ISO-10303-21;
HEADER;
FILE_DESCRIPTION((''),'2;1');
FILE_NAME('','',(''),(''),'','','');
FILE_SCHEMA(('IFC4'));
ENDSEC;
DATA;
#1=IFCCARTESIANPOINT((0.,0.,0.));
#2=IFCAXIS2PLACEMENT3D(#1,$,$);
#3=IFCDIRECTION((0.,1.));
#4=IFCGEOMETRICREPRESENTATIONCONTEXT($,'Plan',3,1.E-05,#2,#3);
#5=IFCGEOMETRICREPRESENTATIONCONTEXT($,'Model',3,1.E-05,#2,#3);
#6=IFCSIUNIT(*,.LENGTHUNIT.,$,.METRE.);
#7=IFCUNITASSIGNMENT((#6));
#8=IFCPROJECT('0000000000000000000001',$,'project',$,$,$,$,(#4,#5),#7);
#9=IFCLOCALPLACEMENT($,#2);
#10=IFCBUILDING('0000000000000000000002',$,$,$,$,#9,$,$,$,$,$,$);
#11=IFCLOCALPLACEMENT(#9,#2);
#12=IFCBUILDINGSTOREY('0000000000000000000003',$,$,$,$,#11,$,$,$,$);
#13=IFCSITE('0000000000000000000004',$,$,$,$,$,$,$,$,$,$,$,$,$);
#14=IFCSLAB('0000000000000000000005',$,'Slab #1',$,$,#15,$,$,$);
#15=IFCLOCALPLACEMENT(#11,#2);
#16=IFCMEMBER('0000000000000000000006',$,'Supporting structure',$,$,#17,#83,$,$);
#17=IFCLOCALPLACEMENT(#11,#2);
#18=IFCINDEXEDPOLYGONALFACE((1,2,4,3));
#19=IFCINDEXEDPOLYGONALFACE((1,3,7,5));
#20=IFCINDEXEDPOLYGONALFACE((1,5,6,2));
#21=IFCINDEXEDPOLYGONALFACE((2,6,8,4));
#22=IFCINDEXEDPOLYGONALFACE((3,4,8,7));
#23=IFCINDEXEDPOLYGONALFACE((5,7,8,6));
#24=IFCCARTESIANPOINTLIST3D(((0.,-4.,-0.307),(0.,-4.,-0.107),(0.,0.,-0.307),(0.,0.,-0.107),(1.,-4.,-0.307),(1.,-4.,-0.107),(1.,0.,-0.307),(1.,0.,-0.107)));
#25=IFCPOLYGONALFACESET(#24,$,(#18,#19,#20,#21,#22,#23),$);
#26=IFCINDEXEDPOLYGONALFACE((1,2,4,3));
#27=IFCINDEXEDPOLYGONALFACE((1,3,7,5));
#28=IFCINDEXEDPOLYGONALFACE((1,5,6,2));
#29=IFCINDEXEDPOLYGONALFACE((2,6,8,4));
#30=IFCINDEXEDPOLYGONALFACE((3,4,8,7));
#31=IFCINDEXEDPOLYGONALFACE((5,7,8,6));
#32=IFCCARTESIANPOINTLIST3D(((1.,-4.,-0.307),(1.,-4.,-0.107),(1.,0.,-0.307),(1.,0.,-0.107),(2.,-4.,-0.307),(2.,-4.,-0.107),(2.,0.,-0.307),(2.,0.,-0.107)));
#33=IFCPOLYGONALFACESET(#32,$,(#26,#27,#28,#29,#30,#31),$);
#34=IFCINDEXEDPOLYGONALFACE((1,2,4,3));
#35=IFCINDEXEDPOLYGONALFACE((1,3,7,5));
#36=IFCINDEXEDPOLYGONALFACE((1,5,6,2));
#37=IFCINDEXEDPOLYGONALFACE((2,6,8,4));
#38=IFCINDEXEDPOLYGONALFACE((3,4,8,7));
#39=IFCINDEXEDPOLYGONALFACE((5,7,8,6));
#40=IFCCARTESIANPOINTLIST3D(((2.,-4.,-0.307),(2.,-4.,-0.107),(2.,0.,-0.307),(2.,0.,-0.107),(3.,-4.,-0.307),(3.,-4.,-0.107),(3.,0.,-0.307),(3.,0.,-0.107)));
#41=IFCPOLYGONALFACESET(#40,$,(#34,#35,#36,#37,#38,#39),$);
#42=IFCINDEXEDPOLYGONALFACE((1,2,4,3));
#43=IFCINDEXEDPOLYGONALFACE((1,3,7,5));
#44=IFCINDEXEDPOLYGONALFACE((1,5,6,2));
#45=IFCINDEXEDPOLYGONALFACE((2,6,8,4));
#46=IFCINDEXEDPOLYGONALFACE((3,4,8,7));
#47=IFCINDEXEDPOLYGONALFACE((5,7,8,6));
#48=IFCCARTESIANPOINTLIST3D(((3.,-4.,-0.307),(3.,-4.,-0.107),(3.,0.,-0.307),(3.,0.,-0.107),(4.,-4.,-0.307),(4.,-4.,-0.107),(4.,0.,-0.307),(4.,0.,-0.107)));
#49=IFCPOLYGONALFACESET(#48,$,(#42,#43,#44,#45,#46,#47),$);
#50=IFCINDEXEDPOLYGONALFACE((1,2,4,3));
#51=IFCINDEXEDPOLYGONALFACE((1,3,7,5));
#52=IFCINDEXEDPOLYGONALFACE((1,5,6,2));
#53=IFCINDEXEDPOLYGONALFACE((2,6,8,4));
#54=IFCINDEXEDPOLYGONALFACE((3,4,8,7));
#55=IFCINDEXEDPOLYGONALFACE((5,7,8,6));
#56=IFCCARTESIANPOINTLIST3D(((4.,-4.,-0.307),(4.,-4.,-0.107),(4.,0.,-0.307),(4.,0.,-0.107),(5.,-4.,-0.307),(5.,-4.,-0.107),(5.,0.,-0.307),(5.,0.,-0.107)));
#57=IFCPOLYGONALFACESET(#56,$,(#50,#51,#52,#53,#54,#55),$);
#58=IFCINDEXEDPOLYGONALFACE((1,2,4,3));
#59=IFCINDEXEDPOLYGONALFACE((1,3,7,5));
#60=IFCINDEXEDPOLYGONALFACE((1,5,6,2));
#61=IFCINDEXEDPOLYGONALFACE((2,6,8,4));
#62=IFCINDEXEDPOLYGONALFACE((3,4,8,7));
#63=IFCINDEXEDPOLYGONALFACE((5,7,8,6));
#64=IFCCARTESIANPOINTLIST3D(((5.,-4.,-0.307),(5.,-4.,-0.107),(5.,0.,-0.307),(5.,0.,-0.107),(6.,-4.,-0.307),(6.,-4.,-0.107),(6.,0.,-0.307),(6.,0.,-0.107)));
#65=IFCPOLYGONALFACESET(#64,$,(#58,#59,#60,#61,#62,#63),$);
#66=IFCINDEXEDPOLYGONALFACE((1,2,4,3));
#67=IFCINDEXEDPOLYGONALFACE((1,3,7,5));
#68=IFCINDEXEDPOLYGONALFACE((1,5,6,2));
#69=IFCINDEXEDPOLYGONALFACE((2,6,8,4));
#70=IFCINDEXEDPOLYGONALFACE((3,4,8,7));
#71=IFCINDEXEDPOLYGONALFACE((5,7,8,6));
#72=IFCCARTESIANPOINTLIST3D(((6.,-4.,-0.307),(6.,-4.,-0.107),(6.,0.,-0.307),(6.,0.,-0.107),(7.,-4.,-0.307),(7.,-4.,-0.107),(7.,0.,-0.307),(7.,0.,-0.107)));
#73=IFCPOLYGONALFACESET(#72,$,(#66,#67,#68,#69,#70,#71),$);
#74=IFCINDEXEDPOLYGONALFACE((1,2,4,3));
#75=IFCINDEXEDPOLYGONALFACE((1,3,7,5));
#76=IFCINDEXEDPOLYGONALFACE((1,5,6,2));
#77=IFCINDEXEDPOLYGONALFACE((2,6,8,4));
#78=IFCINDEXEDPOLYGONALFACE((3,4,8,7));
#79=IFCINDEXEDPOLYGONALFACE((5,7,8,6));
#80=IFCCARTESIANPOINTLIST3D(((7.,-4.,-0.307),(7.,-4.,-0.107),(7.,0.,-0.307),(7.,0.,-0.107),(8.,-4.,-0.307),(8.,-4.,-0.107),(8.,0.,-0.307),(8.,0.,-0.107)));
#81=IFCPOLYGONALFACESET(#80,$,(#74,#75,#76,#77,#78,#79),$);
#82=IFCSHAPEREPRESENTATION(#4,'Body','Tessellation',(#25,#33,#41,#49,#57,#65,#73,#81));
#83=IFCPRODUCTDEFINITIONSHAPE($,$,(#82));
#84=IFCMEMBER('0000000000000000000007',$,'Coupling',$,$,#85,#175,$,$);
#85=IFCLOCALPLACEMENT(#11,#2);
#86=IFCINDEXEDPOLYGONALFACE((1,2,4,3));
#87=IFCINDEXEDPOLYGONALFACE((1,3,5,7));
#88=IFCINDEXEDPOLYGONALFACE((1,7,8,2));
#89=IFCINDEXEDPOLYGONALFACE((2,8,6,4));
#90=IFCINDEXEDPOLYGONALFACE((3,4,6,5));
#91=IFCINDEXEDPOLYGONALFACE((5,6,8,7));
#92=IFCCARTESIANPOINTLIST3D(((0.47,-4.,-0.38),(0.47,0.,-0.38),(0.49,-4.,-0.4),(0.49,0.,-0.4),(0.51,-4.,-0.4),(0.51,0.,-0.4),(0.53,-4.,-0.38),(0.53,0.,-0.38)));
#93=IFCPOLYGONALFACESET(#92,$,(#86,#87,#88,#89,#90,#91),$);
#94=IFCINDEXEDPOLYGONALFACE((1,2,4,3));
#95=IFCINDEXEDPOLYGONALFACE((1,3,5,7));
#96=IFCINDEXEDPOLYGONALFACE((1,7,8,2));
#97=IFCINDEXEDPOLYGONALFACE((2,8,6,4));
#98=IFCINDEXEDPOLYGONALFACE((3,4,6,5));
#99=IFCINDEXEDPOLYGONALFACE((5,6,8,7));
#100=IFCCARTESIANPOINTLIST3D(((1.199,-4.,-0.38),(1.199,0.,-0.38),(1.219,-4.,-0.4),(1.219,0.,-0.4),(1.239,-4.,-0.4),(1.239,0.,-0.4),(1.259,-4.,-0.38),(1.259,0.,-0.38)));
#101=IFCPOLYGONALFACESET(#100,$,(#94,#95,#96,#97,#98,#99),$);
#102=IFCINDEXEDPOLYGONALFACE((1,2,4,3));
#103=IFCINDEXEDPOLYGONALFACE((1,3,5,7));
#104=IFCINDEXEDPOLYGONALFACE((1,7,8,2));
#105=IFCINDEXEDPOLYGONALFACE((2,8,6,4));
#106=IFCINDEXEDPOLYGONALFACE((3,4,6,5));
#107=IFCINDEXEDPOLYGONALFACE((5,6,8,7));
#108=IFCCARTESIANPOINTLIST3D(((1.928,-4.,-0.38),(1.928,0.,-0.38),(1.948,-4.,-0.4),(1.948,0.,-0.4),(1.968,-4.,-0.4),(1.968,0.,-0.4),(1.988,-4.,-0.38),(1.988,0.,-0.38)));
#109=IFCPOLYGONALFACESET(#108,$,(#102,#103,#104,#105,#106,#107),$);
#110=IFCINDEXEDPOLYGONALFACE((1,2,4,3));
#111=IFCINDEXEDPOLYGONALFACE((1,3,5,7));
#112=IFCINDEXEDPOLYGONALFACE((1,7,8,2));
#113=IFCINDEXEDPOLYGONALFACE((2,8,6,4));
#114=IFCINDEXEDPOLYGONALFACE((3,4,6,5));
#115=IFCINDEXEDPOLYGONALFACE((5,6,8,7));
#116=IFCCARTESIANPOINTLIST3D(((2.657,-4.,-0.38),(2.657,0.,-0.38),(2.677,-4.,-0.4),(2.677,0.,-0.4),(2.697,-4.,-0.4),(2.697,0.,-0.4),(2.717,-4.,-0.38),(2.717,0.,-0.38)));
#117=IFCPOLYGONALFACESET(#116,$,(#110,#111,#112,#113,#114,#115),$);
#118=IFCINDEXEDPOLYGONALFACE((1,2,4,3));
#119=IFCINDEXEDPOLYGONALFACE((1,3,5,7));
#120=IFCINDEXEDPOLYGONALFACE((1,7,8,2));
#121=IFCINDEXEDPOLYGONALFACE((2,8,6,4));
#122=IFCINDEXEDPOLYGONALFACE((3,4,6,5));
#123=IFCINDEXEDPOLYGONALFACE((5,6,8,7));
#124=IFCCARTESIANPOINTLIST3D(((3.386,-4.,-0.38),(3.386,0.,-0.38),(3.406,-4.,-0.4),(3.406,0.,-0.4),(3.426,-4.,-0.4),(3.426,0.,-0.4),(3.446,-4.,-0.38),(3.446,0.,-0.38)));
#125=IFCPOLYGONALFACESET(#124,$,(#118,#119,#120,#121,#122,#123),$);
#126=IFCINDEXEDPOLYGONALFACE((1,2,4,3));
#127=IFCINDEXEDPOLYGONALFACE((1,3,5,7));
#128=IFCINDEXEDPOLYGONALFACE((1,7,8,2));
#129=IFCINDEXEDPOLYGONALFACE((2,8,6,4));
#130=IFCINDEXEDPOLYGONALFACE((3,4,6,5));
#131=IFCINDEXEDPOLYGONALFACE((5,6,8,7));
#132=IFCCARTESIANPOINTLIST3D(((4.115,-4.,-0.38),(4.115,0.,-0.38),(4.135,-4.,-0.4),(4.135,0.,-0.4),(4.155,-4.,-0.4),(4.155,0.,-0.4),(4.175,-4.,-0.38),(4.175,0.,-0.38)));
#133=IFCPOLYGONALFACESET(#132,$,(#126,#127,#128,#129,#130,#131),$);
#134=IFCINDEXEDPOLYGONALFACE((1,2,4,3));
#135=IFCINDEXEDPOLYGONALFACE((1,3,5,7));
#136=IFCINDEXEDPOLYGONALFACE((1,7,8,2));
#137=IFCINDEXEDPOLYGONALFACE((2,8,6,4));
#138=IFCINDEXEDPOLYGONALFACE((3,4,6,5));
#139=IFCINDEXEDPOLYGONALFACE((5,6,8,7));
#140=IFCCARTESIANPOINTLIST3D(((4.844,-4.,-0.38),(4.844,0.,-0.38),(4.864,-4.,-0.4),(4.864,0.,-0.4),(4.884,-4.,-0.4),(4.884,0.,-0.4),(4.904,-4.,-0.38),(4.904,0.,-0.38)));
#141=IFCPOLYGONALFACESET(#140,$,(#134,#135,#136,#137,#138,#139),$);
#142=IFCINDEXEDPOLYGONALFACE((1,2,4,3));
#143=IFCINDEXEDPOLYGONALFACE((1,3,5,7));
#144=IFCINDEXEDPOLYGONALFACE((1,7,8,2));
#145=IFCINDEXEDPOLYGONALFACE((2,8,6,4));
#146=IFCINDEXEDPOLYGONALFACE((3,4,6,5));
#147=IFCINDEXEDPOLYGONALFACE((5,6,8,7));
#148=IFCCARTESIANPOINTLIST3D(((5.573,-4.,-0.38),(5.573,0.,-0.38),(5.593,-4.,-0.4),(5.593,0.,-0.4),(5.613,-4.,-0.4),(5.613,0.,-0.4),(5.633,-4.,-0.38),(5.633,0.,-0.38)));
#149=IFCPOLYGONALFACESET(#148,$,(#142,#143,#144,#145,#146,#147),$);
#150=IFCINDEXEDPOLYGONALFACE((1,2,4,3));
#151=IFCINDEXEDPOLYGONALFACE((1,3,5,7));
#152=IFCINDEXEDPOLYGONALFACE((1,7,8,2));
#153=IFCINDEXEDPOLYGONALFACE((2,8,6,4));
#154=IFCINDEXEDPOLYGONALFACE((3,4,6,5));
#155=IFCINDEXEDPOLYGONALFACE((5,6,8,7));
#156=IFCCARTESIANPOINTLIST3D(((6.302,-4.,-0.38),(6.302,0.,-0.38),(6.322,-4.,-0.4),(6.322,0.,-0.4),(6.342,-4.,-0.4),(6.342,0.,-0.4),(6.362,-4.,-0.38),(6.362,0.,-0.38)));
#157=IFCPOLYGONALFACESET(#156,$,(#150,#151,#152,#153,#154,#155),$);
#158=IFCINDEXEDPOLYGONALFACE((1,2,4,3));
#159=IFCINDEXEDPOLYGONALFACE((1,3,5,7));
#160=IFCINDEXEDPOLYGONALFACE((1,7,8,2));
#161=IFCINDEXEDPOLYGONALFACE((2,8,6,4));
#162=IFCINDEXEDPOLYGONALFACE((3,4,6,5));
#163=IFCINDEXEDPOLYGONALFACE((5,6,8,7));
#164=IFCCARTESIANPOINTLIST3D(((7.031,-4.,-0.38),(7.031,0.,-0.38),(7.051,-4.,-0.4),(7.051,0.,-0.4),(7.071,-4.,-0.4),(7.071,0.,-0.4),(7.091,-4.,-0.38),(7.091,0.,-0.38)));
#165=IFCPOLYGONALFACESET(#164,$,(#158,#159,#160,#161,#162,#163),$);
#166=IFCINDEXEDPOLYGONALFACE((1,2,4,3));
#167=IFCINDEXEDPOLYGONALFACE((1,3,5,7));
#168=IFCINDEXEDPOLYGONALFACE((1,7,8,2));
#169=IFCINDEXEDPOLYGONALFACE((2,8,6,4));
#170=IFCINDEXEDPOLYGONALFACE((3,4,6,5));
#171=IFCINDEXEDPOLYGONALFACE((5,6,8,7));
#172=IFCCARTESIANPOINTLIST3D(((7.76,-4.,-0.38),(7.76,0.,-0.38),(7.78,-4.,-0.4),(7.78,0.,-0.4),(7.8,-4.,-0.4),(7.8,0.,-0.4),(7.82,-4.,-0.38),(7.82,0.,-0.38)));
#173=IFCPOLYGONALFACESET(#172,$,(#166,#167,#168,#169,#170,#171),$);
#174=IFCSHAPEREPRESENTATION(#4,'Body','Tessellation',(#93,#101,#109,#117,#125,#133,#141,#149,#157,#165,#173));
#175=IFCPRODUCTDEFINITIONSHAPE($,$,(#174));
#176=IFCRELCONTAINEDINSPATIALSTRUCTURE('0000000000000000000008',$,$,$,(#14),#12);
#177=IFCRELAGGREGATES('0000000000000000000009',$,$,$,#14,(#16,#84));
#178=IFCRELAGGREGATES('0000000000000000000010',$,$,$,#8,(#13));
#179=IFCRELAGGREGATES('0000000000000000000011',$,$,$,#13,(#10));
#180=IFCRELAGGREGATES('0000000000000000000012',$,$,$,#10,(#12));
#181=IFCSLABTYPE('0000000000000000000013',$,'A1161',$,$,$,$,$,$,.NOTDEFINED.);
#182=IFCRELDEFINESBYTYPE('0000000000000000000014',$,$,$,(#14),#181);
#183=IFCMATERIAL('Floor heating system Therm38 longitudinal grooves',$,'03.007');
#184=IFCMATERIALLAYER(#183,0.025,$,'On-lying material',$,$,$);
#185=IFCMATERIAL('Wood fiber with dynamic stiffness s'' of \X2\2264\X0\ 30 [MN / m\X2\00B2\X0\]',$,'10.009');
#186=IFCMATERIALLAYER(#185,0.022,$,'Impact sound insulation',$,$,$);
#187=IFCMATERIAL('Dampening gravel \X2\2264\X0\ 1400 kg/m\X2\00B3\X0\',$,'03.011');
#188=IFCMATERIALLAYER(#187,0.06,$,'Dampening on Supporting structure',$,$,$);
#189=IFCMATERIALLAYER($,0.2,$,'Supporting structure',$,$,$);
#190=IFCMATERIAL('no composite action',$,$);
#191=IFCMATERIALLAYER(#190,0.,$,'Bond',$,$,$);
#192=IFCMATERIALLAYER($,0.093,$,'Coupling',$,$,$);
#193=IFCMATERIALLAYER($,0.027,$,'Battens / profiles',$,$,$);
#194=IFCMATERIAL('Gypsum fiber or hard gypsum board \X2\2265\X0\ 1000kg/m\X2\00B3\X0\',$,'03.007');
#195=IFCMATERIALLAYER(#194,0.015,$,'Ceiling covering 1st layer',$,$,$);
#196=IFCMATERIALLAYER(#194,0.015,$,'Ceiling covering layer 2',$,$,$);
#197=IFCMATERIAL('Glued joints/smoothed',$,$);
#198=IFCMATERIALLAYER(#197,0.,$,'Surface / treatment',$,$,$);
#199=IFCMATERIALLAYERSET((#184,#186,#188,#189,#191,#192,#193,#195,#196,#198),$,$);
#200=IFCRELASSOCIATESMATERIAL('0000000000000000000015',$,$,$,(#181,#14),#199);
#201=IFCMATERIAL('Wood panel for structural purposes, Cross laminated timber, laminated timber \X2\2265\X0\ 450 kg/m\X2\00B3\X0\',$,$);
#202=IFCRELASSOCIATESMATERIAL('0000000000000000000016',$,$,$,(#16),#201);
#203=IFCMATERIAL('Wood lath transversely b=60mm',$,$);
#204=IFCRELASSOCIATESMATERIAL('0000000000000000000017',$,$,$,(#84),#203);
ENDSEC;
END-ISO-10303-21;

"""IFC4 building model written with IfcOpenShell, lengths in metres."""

from ifc_helpers import new_model, si_unit, direction, frame, frame_2d, origin, place, context, project, spatial, polyline, rectangle, outline, extrude, material, layer, layer_set, type_object, element, aggregate, save


model = new_model("IFC4")

# Units and contexts
plan_context = context("Plan", 3, precision=1e-05, world=origin(), true_north=direction((0.0, 1.0)))
model_context = context("Model", 3, precision=1e-05, world=origin(), true_north=direction((0.0, 1.0)))
ifc_project = project(units=[si_unit("LENGTHUNIT", "METRE")], contexts=[plan_context, model_context])

# Site, building, storey
site = spatial("IfcSite", under=ifc_project)
building_placement = place(None, origin())
building = spatial("IfcBuilding", under=site, at=building_placement)
storey_placement = place(building_placement, origin())
storey = spatial("IfcBuildingStorey", under=building, at=storey_placement)

# Slab, members
ifc_material_1 = material(Name="Floor heating system Therm38 longitudinal grooves", Category="03.007")
ifc_layer_1 = layer(ifc_material_1, 0.025, Name="On-lying material")
ifc_material_2 = material(Name="Wood fiber with dynamic stiffness s' of ≤ 30 [MN / m²]", Category="10.009")
ifc_layer_2 = layer(ifc_material_2, 0.022, Name="Impact sound insulation")
ifc_material_3 = material(Name="Dampening gravel ≤ 1400 kg/m³", Category="03.011")
ifc_layer_3 = layer(ifc_material_3, 0.06, Name="Dampening on Supporting structure")
ifc_layer_4 = layer(None, 0.2, Name="Supporting structure")
ifc_material_4 = material(Name="no composite action")
ifc_layer_5 = layer(ifc_material_4, 0.0, Name="Bond")
ifc_layer_6 = layer(None, 0.093, Name="Coupling")
ifc_layer_7 = layer(None, 0.027, Name="Battens / profiles")
ifc_material_5 = material(Name="Gypsum fiber or hard gypsum board ≥ 1000kg/m³", Category="03.007")
ifc_layer_8 = layer(ifc_material_5, 0.015, Name="Ceiling covering 1st layer")
ifc_layer_9 = layer(ifc_material_5, 0.015, Name="Ceiling covering layer 2")
ifc_material_6 = material(Name="Glued joints/smoothed")
ifc_layer_10 = layer(ifc_material_6, 0.0, Name="Surface / treatment")
ifc_layer_set = layer_set([ifc_layer_1, ifc_layer_2, ifc_layer_3, ifc_layer_4, ifc_layer_5, ifc_layer_6, ifc_layer_7, ifc_layer_8, ifc_layer_9, ifc_layer_10])
slab_type = type_object("IfcSlabType", Name="A1161", PredefinedType="NOTDEFINED", material=ifc_layer_set)
slab_placement = place(None, frame((0.0, 0.0, 0.0), z_axis=(0.0, 0.0, -1.0), x_axis=(1.0, 0.0, 0.0)))
slab = element("IfcSlab", 1, at=slab_placement, inside=storey, type_object=slab_type, material=ifc_layer_set, Name="Slab #1")
ifc_material_7 = material(Name="Wood panel for structural purposes, Cross laminated timber, laminated timber ≥ 450 kg/m³")
member_1_placement = place(slab_placement, origin())
member_1 = element("IfcMember", 2, at=member_1_placement, material=ifc_material_7, Name="Supporting structure", context=plan_context, shape_type="SweptSolid", body=[
    extrude(rectangle(XDim=1.0, YDim=0.2, at=frame_2d((0.5, 0.1), x_axis=(1.0, 0.0))), frame((0.0, 4.0, 0.107), z_axis=(0.0, -1.0, 0.0), x_axis=(1.0, 0.0, 0.0)), (0.0, 0.0, 1.0), 4.0),
    extrude(rectangle(XDim=1.0, YDim=0.2, at=frame_2d((0.5, 0.1), x_axis=(1.0, 0.0))), frame((1.0, 4.0, 0.107), z_axis=(0.0, -1.0, 0.0), x_axis=(1.0, 0.0, 0.0)), (0.0, 0.0, 1.0), 4.0),
    extrude(rectangle(XDim=1.0, YDim=0.2, at=frame_2d((0.5, 0.1), x_axis=(1.0, 0.0))), frame((2.0, 4.0, 0.107), z_axis=(0.0, -1.0, 0.0), x_axis=(1.0, 0.0, 0.0)), (0.0, 0.0, 1.0), 4.0),
    extrude(rectangle(XDim=1.0, YDim=0.2, at=frame_2d((0.5, 0.1), x_axis=(1.0, 0.0))), frame((3.0, 4.0, 0.107), z_axis=(0.0, -1.0, 0.0), x_axis=(1.0, 0.0, 0.0)), (0.0, 0.0, 1.0), 4.0),
    extrude(rectangle(XDim=1.0, YDim=0.2, at=frame_2d((0.5, 0.1), x_axis=(1.0, 0.0))), frame((4.0, 4.0, 0.107), z_axis=(0.0, -1.0, 0.0), x_axis=(1.0, 0.0, 0.0)), (0.0, 0.0, 1.0), 4.0),
    extrude(rectangle(XDim=1.0, YDim=0.2, at=frame_2d((0.5, 0.1), x_axis=(1.0, 0.0))), frame((5.0, 4.0, 0.107), z_axis=(0.0, -1.0, 0.0), x_axis=(1.0, 0.0, 0.0)), (0.0, 0.0, 1.0), 4.0),
    extrude(rectangle(XDim=1.0, YDim=0.2, at=frame_2d((0.5, 0.1), x_axis=(1.0, 0.0))), frame((6.0, 4.0, 0.107), z_axis=(0.0, -1.0, 0.0), x_axis=(1.0, 0.0, 0.0)), (0.0, 0.0, 1.0), 4.0),
    extrude(rectangle(XDim=1.0, YDim=0.2, at=frame_2d((0.5, 0.1), x_axis=(1.0, 0.0))), frame((7.0, 4.0, 0.107), z_axis=(0.0, -1.0, 0.0), x_axis=(1.0, 0.0, 0.0)), (0.0, 0.0, 1.0), 4.0),
])
ifc_material_8 = material(Name="Wood lath transversely b=60mm")
member_2_placement = place(slab_placement, origin())
member_2 = element("IfcMember", 3, at=member_2_placement, material=ifc_material_8, Name="Coupling", context=plan_context, shape_type="SweptSolid", body=[
    extrude(outline(polyline([(0.0, 0.0), (0.06, 0.0), (0.04, 0.02), (0.02, 0.02), (0.0, 0.0)])), frame((0.47, 4.0, 0.38), z_axis=(0.0, -1.0, 0.0), x_axis=(1.0, 0.0, 0.0)), (0.0, 0.0, 1.0), 4.0),
    extrude(outline(polyline([(0.0, 0.0), (0.06, 0.0), (0.04, 0.02), (0.02, 0.02), (0.0, 0.0)])), frame((1.199, 4.0, 0.38), z_axis=(0.0, -1.0, 0.0), x_axis=(1.0, 0.0, 0.0)), (0.0, 0.0, 1.0), 4.0),
    extrude(outline(polyline([(0.0, 0.0), (0.06, 0.0), (0.04, 0.02), (0.02, 0.02), (0.0, 0.0)])), frame((1.928, 4.0, 0.38), z_axis=(0.0, -1.0, 0.0), x_axis=(1.0, 0.0, 0.0)), (0.0, 0.0, 1.0), 4.0),
    extrude(outline(polyline([(0.0, 0.0), (0.06, 0.0), (0.04, 0.02), (0.02, 0.02), (0.0, 0.0)])), frame((2.657, 4.0, 0.38), z_axis=(0.0, -1.0, 0.0), x_axis=(1.0, 0.0, 0.0)), (0.0, 0.0, 1.0), 4.0),
    extrude(outline(polyline([(0.0, 0.0), (0.06, 0.0), (0.04, 0.02), (0.02, 0.02), (0.0, 0.0)])), frame((3.386, 4.0, 0.38), z_axis=(0.0, -1.0, 0.0), x_axis=(1.0, 0.0, 0.0)), (0.0, 0.0, 1.0), 4.0),
    extrude(outline(polyline([(0.0, 0.0), (0.06, 0.0), (0.04, 0.02), (0.02, 0.02), (0.0, 0.0)])), frame((4.115, 4.0, 0.38), z_axis=(0.0, -1.0, 0.0), x_axis=(1.0, 0.0, 0.0)), (0.0, 0.0, 1.0), 4.0),
    extrude(outline(polyline([(0.0, 0.0), (0.06, 0.0), (0.04, 0.02), (0.02, 0.02), (0.0, 0.0)])), frame((4.844, 4.0, 0.38), z_axis=(0.0, -1.0, 0.0), x_axis=(1.0, 0.0, 0.0)), (0.0, 0.0, 1.0), 4.0),
    extrude(outline(polyline([(0.0, 0.0), (0.06, 0.0), (0.04, 0.02), (0.02, 0.02), (0.0, 0.0)])), frame((5.573, 4.0, 0.38), z_axis=(0.0, -1.0, 0.0), x_axis=(1.0, 0.0, 0.0)), (0.0, 0.0, 1.0), 4.0),
    extrude(outline(polyline([(0.0, 0.0), (0.06, 0.0), (0.04, 0.02), (0.02, 0.02), (0.0, 0.0)])), frame((6.302, 4.0, 0.38), z_axis=(0.0, -1.0, 0.0), x_axis=(1.0, 0.0, 0.0)), (0.0, 0.0, 1.0), 4.0),
    extrude(outline(polyline([(0.0, 0.0), (0.06, 0.0), (0.04, 0.02), (0.02, 0.02), (0.0, 0.0)])), frame((7.031, 4.0, 0.38), z_axis=(0.0, -1.0, 0.0), x_axis=(1.0, 0.0, 0.0)), (0.0, 0.0, 1.0), 4.0),
    extrude(outline(polyline([(0.0, 0.0), (0.06, 0.0), (0.04, 0.02), (0.02, 0.02), (0.0, 0.0)])), frame((7.76, 4.0, 0.38), z_axis=(0.0, -1.0, 0.0), x_axis=(1.0, 0.0, 0.0)), (0.0, 0.0, 1.0), 4.0),
])
aggregate(slab, [member_1, member_2])

save(model, "model.ifc")
